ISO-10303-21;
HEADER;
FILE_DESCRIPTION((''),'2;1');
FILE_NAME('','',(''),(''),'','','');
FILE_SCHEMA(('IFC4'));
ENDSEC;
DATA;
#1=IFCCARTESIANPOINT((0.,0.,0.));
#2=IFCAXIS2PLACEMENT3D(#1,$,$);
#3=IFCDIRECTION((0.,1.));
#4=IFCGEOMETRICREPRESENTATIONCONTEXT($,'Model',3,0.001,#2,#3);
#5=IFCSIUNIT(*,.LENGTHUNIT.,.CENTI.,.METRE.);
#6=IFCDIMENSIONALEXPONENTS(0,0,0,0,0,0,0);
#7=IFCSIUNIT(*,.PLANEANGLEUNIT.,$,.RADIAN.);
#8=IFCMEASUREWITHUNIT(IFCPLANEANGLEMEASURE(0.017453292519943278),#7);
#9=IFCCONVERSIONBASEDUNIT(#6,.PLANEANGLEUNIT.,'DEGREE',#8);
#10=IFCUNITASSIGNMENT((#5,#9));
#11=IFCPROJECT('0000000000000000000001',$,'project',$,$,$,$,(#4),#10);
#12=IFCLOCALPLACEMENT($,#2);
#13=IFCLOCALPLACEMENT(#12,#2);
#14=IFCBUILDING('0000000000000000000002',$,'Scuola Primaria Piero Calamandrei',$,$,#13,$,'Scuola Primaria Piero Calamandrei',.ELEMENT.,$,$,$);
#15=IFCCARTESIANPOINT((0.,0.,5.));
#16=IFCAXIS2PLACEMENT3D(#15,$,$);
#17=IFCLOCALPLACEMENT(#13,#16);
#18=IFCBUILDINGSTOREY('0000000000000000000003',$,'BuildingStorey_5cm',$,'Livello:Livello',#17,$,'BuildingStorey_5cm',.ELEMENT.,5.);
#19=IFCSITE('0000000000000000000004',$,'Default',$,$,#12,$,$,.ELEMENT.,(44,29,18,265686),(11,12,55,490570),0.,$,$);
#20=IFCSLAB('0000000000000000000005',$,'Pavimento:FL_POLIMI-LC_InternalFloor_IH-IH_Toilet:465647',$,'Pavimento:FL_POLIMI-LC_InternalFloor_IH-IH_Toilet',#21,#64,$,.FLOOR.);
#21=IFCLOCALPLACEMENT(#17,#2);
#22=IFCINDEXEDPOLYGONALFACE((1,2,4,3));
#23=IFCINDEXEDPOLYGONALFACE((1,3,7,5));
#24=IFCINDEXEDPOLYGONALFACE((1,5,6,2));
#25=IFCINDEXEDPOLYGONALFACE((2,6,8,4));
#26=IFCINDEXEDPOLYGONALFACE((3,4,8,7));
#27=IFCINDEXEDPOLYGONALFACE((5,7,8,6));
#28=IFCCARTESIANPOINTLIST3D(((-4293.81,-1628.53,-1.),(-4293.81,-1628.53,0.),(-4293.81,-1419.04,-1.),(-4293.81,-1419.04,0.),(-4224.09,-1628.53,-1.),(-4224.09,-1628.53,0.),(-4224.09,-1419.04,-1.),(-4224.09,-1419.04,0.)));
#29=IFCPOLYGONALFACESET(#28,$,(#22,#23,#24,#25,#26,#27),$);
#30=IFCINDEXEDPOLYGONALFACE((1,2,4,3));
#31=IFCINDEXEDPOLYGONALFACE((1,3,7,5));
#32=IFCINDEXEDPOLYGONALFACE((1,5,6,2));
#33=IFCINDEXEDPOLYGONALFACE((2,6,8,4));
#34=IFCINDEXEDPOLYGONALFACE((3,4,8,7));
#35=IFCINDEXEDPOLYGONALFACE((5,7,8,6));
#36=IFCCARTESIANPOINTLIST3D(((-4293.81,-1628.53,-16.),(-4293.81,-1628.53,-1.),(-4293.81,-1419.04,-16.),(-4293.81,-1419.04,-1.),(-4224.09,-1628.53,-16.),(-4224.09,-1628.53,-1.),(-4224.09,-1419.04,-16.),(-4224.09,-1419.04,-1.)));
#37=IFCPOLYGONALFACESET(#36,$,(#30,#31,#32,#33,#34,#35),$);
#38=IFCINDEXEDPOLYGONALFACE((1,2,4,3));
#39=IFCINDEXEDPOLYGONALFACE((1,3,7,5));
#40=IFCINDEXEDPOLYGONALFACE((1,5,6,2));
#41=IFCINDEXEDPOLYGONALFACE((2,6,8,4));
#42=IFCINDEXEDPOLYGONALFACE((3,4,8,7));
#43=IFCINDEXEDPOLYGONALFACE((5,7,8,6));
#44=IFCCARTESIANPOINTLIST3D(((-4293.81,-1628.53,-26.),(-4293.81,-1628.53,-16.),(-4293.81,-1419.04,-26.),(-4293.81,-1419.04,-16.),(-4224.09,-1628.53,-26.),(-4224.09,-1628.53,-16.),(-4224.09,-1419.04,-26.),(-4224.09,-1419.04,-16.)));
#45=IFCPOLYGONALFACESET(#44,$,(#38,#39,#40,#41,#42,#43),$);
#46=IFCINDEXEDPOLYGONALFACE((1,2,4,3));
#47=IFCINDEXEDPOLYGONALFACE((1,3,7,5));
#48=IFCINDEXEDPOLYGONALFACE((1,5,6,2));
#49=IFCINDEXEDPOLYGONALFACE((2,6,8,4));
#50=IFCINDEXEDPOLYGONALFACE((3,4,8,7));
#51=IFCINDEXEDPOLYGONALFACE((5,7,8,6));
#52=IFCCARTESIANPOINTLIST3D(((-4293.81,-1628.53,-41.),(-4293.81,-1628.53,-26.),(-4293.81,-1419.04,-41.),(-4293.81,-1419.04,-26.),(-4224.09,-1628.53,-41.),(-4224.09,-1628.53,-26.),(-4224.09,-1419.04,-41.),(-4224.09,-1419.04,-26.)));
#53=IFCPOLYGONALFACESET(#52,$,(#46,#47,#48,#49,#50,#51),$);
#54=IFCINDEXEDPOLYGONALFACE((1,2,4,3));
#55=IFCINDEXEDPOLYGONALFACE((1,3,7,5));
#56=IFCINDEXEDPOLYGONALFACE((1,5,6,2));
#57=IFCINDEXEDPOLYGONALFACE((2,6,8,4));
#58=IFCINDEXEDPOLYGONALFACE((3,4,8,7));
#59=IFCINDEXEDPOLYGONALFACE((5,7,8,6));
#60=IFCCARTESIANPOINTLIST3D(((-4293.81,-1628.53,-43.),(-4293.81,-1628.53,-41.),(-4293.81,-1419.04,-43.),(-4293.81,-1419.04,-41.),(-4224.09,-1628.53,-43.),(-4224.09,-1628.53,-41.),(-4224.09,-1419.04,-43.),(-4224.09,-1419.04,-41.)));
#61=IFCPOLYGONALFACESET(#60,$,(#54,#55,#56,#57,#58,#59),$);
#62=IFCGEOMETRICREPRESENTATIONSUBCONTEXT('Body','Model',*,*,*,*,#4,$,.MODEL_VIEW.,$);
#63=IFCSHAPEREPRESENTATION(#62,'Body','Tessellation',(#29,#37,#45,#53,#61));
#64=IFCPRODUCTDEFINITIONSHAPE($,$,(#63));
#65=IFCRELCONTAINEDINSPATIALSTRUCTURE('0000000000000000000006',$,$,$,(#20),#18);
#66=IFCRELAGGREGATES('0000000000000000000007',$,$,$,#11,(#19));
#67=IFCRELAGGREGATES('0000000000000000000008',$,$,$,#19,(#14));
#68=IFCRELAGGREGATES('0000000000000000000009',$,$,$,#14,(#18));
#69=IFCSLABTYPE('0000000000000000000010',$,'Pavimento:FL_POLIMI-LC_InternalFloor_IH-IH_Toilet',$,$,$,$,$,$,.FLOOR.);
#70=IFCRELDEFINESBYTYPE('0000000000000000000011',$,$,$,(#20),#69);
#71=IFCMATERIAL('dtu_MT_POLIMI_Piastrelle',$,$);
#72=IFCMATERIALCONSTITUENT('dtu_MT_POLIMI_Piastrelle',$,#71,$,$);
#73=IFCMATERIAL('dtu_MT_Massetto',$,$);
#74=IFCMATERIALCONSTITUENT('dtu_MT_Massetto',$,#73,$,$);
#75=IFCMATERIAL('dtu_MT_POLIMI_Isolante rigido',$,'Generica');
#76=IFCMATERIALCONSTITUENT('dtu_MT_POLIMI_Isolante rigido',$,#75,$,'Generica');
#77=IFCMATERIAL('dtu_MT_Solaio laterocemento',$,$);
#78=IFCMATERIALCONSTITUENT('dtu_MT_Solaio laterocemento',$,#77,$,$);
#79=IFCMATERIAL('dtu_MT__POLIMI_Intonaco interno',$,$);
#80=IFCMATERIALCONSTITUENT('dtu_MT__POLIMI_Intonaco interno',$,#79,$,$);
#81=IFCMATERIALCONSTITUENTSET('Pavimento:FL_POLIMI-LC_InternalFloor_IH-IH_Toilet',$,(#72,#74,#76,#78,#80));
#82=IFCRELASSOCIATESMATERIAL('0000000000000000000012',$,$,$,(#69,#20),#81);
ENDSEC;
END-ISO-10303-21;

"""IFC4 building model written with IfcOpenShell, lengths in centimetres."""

from ifc_helpers import new_model, entity, si_unit, converted_unit, direction, frame, origin, place, context, subcontext, project, spatial, indexed_curve, outline, extrude, material, constituent, constituent_set, type_object, element, save


model = new_model("IFC4")

# Units and contexts
model_context = context("Model", 3, precision=0.001, world=origin(), true_north=direction((0.0, 1.0)))
body_context = subcontext(model_context, "Body", "Model", "MODEL_VIEW")
ifc_project = project(units=[si_unit("LENGTHUNIT", "METRE", prefix="CENTI"), converted_unit("PLANEANGLEUNIT", "DEGREE", entity("IfcPlaneAngleMeasure", 0.017453292519943278), si_unit("PLANEANGLEUNIT", "RADIAN"), dimensions=[0, 0, 0, 0, 0, 0, 0])], contexts=[model_context])

# Site, building, storey
site_placement = place(None, origin())
site = spatial("IfcSite", under=ifc_project, at=site_placement, Name="Default", CompositionType="ELEMENT", RefLatitude=(44, 29, 18, 265686), RefLongitude=(11, 12, 55, 490570), RefElevation=0.0)
building_placement = place(site_placement, origin())
building = spatial("IfcBuilding", under=site, at=building_placement, Name="Scuola Primaria Piero Calamandrei", LongName="Scuola Primaria Piero Calamandrei", CompositionType="ELEMENT")
storey_placement = place(building_placement, frame((0.0, 0.0, 5.0)))
storey = spatial("IfcBuildingStorey", under=building, at=storey_placement, Name="BuildingStorey_5cm", ObjectType="Livello:Livello", LongName="BuildingStorey_5cm", CompositionType="ELEMENT", Elevation=5.0)

# Slab
ifc_material_1 = material(Name="dtu_MT_Massetto")
ifc_material_2 = material(Name="dtu_MT_POLIMI_Isolante rigido", Category="Generica")
ifc_material_3 = material(Name="dtu_MT_Solaio laterocemento")
ifc_material_4 = material(Name="dtu_MT__POLIMI_Intonaco interno")
ifc_material_5 = material(Name="dtu_MT_POLIMI_Piastrelle")
ifc_constituent_1 = constituent(ifc_material_5, Name="dtu_MT_POLIMI_Piastrelle")
ifc_constituent_2 = constituent(ifc_material_1, Name="dtu_MT_Massetto")
ifc_constituent_3 = constituent(ifc_material_2, Name="dtu_MT_POLIMI_Isolante rigido", Category="Generica")
ifc_constituent_4 = constituent(ifc_material_3, Name="dtu_MT_Solaio laterocemento")
ifc_constituent_5 = constituent(ifc_material_4, Name="dtu_MT__POLIMI_Intonaco interno")
ifc_constituent_set_1 = constituent_set(constituents=[ifc_constituent_1, ifc_constituent_2, ifc_constituent_3, ifc_constituent_4, ifc_constituent_5], Name="Pavimento:FL_POLIMI-LC_InternalFloor_IH-IH_Toilet")
slab_type_1 = type_object("IfcSlabType", Name="Pavimento:FL_POLIMI-LC_InternalFloor_IH-IH_Toilet", PredefinedType="FLOOR", material=ifc_constituent_set_1)
slab_1_placement = place(storey_placement, origin())
element("IfcSlab", 1, at=slab_1_placement, inside=storey, type_object=slab_type_1, material=ifc_constituent_set_1, Name="Pavimento:FL_POLIMI-LC_InternalFloor_IH-IH_Toilet:465647", ObjectType="Pavimento:FL_POLIMI-LC_InternalFloor_IH-IH_Toilet", PredefinedType="FLOOR", context=body_context, shape_type="SweptSolid", body=[
    extrude(outline(indexed_curve([(-104.74, -34.86), (104.74, -34.86), (104.74, 34.86), (-104.74, 34.86), (-104.74, -34.86)], self_intersect=False)), frame((-4258.95, -1523.78, -1.0), z_axis=(0.0, 0.0, 1.0), x_axis=(0.0, 1.0, 0.0)), (0.0, 0.0, 1.0), 1.0),
    extrude(outline(indexed_curve([(-104.74, -34.86), (104.74, -34.86), (104.74, 34.86), (-104.74, 34.86), (-104.74, -34.86)], self_intersect=False)), frame((-4258.95, -1523.78, -16.0), z_axis=(0.0, 0.0, 1.0), x_axis=(0.0, 1.0, 0.0)), (0.0, 0.0, 1.0), 15.0),
    extrude(outline(indexed_curve([(-104.74, -34.86), (104.74, -34.86), (104.74, 34.86), (-104.74, 34.86), (-104.74, -34.86)], self_intersect=False)), frame((-4258.95, -1523.78, -26.0), z_axis=(0.0, 0.0, 1.0), x_axis=(0.0, 1.0, 0.0)), (0.0, 0.0, 1.0), 10.0),
    extrude(outline(indexed_curve([(-104.74, -34.86), (104.74, -34.86), (104.74, 34.86), (-104.74, 34.86), (-104.74, -34.86)], self_intersect=False)), frame((-4258.95, -1523.78, -41.0), z_axis=(0.0, 0.0, 1.0), x_axis=(0.0, 1.0, 0.0)), (0.0, 0.0, 1.0), 15.0),
    extrude(outline(indexed_curve([(-104.74, -34.86), (104.74, -34.86), (104.74, 34.86), (-104.74, 34.86), (-104.74, -34.86)], self_intersect=False)), frame((-4258.95, -1523.78, -43.0), z_axis=(0.0, 0.0, 1.0), x_axis=(0.0, 1.0, 0.0)), (0.0, 0.0, 1.0), 2.0),
])

save(model, "model.ifc")
